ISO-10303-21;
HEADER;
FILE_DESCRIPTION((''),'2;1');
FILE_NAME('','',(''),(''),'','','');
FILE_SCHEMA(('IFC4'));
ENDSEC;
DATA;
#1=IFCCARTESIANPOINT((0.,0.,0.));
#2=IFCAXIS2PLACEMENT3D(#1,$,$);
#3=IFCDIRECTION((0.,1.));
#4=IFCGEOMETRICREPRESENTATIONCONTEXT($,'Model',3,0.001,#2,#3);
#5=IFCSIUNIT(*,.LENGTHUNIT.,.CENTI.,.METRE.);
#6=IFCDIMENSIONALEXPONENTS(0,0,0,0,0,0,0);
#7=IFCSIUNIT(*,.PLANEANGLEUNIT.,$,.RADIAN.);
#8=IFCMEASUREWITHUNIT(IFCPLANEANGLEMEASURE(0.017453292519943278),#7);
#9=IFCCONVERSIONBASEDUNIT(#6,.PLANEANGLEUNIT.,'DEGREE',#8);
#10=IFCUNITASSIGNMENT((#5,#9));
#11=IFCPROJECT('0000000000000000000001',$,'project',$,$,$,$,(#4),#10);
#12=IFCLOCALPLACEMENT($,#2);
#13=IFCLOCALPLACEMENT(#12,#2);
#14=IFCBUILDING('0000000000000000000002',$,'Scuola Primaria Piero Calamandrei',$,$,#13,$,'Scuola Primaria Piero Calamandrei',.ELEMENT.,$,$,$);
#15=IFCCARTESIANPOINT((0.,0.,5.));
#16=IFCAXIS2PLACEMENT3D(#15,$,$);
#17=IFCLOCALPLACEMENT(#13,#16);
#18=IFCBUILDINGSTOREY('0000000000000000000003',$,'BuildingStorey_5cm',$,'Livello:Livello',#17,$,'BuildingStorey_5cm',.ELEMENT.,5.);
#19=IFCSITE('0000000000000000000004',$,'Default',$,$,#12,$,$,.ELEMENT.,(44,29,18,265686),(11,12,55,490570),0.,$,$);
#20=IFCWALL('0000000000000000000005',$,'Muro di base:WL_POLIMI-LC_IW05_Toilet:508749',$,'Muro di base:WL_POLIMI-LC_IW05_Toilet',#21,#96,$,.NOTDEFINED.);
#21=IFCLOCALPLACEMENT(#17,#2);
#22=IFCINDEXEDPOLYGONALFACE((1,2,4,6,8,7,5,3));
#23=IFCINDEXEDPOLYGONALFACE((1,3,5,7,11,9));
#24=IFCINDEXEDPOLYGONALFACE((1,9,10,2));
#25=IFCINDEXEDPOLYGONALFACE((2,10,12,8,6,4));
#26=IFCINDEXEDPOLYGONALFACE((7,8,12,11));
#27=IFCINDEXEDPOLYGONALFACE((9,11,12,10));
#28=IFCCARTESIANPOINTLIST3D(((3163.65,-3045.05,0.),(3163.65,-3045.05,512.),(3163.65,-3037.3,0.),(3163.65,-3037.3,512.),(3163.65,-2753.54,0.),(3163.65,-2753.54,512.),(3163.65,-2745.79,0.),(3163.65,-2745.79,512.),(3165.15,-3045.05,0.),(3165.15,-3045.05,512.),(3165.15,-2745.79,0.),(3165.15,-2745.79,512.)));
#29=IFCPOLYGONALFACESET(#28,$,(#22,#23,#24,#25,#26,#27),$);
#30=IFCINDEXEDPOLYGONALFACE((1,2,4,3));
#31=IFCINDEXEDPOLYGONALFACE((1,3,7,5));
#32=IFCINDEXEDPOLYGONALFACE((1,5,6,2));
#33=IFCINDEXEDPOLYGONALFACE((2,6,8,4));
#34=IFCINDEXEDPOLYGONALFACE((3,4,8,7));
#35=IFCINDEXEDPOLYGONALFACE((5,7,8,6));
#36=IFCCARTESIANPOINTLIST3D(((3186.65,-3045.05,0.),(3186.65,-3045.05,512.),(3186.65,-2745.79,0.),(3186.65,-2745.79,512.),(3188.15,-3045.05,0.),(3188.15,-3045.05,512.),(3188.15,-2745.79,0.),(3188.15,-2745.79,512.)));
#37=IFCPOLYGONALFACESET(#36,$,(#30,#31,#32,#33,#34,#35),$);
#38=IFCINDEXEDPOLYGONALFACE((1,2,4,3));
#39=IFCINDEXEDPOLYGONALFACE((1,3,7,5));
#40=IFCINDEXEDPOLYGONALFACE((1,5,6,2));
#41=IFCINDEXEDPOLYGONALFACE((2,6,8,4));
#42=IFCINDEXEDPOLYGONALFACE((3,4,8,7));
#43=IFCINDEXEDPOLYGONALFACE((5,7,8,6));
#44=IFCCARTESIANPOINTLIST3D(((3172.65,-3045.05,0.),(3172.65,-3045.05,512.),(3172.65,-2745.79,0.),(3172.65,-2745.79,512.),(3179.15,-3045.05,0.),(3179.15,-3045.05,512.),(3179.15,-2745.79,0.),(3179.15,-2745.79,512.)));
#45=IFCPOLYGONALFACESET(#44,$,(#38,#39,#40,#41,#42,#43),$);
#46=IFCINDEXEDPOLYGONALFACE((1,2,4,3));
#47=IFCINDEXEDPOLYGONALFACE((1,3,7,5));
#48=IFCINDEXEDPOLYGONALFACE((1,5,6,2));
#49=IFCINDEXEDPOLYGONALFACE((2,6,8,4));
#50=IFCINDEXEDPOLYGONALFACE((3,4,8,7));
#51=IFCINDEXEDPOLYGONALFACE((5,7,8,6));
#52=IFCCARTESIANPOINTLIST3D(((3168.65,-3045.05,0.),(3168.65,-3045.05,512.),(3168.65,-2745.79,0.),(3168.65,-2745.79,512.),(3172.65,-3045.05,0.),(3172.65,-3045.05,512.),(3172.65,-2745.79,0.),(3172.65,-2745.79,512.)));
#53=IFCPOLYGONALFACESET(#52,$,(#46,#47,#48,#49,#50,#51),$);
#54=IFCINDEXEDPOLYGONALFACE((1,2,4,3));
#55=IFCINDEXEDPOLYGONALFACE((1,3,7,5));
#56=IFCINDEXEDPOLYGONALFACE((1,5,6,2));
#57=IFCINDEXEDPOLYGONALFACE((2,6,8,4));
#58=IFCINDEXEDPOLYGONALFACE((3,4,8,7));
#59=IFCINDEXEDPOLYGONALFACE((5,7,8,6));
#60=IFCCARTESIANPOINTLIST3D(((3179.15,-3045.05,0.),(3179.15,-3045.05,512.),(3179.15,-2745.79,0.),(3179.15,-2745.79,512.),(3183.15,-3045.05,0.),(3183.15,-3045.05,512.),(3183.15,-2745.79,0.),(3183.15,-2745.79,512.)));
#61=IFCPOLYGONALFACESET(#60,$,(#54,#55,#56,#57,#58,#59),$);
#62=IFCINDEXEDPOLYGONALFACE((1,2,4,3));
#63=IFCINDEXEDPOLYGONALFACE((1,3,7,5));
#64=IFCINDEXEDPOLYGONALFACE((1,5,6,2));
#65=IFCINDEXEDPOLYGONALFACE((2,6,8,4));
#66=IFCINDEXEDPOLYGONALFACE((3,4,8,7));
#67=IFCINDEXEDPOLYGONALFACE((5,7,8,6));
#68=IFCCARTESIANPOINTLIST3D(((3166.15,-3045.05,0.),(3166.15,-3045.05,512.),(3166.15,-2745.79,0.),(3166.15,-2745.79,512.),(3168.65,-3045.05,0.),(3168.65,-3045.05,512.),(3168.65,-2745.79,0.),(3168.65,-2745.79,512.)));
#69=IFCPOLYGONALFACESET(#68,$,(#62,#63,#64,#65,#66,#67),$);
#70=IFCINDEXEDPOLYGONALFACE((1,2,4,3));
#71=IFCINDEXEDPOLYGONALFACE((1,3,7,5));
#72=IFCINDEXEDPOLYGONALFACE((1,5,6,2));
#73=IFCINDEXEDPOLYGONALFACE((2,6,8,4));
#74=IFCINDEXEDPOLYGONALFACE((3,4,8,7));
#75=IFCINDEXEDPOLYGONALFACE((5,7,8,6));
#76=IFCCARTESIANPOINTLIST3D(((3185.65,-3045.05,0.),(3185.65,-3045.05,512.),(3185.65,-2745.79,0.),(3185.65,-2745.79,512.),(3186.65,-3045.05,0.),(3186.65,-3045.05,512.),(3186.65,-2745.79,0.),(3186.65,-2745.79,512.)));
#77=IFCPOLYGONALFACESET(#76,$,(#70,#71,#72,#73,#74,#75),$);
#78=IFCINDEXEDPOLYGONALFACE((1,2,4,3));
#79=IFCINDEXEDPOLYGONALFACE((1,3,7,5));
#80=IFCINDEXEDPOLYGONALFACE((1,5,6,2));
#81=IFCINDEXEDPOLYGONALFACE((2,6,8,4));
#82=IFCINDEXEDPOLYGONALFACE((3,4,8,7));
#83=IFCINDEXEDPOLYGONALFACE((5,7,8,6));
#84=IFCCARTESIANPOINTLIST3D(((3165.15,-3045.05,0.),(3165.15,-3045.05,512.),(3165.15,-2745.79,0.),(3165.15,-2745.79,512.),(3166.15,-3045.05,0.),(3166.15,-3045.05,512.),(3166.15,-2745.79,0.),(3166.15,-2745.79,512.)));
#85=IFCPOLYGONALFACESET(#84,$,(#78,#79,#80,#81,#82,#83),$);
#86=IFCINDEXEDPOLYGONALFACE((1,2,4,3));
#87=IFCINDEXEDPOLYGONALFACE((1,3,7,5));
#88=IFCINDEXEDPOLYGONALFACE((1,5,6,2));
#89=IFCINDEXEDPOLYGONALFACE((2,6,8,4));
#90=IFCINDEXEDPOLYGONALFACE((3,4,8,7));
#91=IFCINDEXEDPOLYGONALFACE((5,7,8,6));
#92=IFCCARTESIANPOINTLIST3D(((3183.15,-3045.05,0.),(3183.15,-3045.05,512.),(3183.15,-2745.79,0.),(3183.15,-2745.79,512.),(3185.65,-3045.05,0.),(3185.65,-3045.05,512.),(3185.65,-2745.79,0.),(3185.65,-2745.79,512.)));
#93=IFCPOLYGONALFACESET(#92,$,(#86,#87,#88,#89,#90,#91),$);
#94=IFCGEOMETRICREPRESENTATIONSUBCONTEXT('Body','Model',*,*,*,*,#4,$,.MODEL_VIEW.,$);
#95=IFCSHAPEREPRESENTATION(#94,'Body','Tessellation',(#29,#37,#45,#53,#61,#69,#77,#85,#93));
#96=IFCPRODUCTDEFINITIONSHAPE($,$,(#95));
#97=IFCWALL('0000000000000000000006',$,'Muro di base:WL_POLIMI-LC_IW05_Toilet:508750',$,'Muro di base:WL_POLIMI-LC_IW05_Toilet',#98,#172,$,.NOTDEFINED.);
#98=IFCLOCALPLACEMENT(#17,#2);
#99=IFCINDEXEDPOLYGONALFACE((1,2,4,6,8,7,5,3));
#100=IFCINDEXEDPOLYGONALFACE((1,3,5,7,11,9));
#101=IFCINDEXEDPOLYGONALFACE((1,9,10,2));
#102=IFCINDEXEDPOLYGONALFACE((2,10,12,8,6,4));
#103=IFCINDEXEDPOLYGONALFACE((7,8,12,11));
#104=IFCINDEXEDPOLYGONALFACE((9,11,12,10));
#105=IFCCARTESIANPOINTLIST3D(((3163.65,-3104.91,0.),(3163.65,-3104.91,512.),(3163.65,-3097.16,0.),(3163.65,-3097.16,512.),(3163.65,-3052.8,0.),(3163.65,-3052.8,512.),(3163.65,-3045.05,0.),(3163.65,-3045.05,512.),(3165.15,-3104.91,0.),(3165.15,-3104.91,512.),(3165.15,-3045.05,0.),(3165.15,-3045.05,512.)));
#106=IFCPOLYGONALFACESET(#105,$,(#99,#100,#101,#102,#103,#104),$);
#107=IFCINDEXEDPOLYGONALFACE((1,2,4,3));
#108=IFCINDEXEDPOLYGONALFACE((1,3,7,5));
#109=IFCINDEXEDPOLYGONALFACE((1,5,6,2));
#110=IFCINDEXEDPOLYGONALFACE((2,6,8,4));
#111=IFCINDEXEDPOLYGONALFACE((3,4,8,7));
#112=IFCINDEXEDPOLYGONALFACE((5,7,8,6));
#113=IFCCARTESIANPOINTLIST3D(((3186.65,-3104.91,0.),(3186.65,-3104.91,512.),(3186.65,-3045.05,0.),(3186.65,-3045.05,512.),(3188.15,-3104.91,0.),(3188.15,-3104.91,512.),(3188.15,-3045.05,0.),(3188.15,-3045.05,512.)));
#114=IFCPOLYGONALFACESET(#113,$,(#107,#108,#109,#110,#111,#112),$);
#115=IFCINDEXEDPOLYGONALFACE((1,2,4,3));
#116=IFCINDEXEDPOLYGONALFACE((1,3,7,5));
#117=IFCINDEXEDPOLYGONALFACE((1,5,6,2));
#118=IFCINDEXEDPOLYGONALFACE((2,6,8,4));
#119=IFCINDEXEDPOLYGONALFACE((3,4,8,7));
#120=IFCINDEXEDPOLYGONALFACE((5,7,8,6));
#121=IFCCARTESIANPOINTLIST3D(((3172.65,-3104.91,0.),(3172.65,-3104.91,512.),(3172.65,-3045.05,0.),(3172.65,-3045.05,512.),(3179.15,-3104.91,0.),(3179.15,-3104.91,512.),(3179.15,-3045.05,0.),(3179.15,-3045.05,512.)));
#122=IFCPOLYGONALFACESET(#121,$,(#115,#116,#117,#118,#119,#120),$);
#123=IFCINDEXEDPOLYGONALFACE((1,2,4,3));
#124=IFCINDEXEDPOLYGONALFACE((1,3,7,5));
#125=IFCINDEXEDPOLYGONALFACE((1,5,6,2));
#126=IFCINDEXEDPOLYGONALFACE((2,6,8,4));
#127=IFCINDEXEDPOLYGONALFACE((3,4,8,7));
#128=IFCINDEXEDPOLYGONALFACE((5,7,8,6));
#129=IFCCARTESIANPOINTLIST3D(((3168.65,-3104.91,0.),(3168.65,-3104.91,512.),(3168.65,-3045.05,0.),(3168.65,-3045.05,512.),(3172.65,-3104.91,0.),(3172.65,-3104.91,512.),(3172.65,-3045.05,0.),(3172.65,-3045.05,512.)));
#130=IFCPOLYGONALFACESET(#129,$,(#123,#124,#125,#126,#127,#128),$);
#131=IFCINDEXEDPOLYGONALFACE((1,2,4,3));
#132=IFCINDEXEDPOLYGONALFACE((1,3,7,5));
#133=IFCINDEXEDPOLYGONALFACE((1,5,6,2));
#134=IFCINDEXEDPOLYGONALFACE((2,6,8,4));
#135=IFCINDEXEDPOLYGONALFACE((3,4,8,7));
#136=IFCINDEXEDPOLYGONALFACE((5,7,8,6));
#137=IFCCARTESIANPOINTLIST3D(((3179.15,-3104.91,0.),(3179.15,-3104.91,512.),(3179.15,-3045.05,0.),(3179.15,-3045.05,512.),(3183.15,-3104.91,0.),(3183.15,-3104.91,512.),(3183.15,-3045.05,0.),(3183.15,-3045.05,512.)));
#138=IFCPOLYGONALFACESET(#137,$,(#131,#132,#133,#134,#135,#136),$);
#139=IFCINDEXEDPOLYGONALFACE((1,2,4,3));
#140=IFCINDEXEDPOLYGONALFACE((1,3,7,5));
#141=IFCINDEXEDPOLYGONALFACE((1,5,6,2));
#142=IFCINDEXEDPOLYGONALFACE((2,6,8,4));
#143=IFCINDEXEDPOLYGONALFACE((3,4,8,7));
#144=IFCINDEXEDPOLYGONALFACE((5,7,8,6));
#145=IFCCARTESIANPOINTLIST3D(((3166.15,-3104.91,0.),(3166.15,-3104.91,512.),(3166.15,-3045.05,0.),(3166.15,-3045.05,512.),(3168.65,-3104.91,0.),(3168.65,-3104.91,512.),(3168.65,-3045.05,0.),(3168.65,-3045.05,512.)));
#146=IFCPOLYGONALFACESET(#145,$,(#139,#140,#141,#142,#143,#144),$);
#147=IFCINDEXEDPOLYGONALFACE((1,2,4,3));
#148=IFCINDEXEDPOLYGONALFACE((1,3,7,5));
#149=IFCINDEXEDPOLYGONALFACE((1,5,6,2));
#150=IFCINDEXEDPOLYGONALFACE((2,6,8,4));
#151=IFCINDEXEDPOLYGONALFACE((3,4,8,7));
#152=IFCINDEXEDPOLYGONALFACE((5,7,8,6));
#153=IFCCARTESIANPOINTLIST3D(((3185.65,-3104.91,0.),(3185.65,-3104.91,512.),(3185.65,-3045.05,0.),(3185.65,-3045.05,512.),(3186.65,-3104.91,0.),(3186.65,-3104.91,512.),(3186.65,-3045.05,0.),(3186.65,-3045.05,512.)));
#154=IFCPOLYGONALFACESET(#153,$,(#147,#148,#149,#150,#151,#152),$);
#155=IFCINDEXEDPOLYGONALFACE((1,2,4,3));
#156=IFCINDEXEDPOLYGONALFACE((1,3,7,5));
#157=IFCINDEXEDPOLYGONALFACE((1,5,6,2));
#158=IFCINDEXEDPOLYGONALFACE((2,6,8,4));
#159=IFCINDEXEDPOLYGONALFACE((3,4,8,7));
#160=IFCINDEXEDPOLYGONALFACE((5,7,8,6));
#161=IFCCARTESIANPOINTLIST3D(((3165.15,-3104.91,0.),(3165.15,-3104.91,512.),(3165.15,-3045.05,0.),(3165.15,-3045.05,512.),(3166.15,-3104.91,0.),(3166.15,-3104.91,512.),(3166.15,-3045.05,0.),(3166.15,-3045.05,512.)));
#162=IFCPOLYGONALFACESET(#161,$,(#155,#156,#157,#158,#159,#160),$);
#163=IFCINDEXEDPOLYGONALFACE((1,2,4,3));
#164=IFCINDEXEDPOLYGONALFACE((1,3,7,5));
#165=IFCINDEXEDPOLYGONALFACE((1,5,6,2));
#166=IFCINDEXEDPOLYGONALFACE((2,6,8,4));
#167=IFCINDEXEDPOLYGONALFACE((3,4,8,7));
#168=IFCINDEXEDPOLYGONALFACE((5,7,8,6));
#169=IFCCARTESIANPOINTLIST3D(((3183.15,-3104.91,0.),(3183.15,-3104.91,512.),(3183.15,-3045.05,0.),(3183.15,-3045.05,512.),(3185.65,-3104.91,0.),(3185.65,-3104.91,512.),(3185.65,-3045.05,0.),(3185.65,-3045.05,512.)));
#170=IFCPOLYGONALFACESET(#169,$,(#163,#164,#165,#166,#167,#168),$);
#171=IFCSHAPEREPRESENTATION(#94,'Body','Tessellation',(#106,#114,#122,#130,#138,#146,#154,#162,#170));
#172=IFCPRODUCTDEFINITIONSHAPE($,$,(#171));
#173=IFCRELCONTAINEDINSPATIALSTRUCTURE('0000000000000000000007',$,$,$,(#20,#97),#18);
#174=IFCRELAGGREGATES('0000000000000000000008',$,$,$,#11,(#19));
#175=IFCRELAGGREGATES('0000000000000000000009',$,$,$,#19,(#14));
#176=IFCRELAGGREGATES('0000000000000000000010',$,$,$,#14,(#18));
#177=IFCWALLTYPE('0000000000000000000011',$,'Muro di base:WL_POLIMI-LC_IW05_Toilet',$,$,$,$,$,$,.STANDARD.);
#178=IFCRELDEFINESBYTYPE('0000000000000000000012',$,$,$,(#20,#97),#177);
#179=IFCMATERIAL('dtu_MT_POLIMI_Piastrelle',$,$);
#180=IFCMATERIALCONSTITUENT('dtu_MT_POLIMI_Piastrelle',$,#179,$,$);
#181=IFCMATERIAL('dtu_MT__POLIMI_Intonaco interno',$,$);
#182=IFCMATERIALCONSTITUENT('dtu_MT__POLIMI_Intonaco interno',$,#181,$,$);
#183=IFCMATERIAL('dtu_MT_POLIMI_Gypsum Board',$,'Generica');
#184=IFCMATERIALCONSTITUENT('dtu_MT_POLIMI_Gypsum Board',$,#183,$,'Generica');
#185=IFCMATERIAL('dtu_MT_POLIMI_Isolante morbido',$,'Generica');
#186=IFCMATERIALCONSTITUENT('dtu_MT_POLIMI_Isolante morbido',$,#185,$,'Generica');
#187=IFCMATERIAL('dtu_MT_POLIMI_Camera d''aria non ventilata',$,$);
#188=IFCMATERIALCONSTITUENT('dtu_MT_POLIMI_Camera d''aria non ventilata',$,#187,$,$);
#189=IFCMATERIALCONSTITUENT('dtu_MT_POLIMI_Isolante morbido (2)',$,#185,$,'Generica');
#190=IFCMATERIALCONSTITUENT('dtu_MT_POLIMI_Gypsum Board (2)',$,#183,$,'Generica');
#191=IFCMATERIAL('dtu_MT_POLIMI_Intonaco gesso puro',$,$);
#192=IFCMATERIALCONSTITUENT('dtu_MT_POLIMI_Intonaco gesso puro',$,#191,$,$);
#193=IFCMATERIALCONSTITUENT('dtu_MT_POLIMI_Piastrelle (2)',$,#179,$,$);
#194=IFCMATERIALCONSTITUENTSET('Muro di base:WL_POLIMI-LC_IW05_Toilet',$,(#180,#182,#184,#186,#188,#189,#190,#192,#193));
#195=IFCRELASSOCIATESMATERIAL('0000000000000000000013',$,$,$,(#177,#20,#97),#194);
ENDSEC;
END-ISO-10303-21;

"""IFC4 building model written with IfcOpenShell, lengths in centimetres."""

from ifc_helpers import new_model, entity, si_unit, converted_unit, direction, frame, origin, place, context, subcontext, project, spatial, indexed_curve, outline, extrude, material, constituent, constituent_set, type_object, element, save


model = new_model("IFC4")

# Units and contexts
model_context = context("Model", 3, precision=0.001, world=origin(), true_north=direction((0.0, 1.0)))
body_context = subcontext(model_context, "Body", "Model", "MODEL_VIEW")
ifc_project = project(units=[si_unit("LENGTHUNIT", "METRE", prefix="CENTI"), converted_unit("PLANEANGLEUNIT", "DEGREE", entity("IfcPlaneAngleMeasure", 0.017453292519943278), si_unit("PLANEANGLEUNIT", "RADIAN"), dimensions=[0, 0, 0, 0, 0, 0, 0])], contexts=[model_context])

# Site, building, storey
site_placement = place(None, origin())
site = spatial("IfcSite", under=ifc_project, at=site_placement, Name="Default", CompositionType="ELEMENT", RefLatitude=(44, 29, 18, 265686), RefLongitude=(11, 12, 55, 490570), RefElevation=0.0)
building_placement = place(site_placement, origin())
building = spatial("IfcBuilding", under=site, at=building_placement, Name="Scuola Primaria Piero Calamandrei", LongName="Scuola Primaria Piero Calamandrei", CompositionType="ELEMENT")
storey_placement = place(building_placement, frame((0.0, 0.0, 5.0)))
storey = spatial("IfcBuildingStorey", under=building, at=storey_placement, Name="BuildingStorey_5cm", ObjectType="Livello:Livello", LongName="BuildingStorey_5cm", CompositionType="ELEMENT", Elevation=5.0)

# Shared definitions
ifc_material_1 = material(Name="dtu_MT_POLIMI_Intonaco gesso puro")

# Shared definitions
ifc_material_2 = material(Name="dtu_MT_POLIMI_Isolante morbido", Category="Generica")
ifc_material_3 = material(Name="dtu_MT_POLIMI_Gypsum Board", Category="Generica")
ifc_material_4 = material(Name="dtu_MT__POLIMI_Intonaco interno")
ifc_material_5 = material(Name="dtu_MT_POLIMI_Camera d'aria non ventilata")

# Walls
ifc_material_6 = material(Name="dtu_MT_POLIMI_Piastrelle")
ifc_constituent_1 = constituent(ifc_material_6, Name="dtu_MT_POLIMI_Piastrelle")
ifc_constituent_2 = constituent(ifc_material_4, Name="dtu_MT__POLIMI_Intonaco interno")
ifc_constituent_3 = constituent(ifc_material_3, Name="dtu_MT_POLIMI_Gypsum Board", Category="Generica")
ifc_constituent_4 = constituent(ifc_material_2, Name="dtu_MT_POLIMI_Isolante morbido", Category="Generica")
ifc_constituent_5 = constituent(ifc_material_5, Name="dtu_MT_POLIMI_Camera d'aria non ventilata")
ifc_constituent_6 = constituent(ifc_material_2, Name="dtu_MT_POLIMI_Isolante morbido (2)", Category="Generica")
ifc_constituent_7 = constituent(ifc_material_3, Name="dtu_MT_POLIMI_Gypsum Board (2)", Category="Generica")
ifc_constituent_8 = constituent(ifc_material_1, Name="dtu_MT_POLIMI_Intonaco gesso puro")
ifc_constituent_9 = constituent(ifc_material_6, Name="dtu_MT_POLIMI_Piastrelle (2)")
ifc_constituent_set_1 = constituent_set(constituents=[ifc_constituent_1, ifc_constituent_2, ifc_constituent_3, ifc_constituent_4, ifc_constituent_5, ifc_constituent_6, ifc_constituent_7, ifc_constituent_8, ifc_constituent_9], Name="Muro di base:WL_POLIMI-LC_IW05_Toilet")
wall_type_1 = type_object("IfcWallType", Name="Muro di base:WL_POLIMI-LC_IW05_Toilet", PredefinedType="STANDARD", material=ifc_constituent_set_1)
wall_1_placement = place(storey_placement, frame((3175.9, -3045.05, 0.0), z_axis=(0.0, 0.0, 1.0), x_axis=(0.0, 1.0, 0.0)))
element("IfcWall", 1, at=wall_1_placement, inside=storey, type_object=wall_type_1, material=ifc_constituent_set_1, Name="Muro di base:WL_POLIMI-LC_IW05_Toilet:508749", ObjectType="Muro di base:WL_POLIMI-LC_IW05_Toilet", PredefinedType="NOTDEFINED", context=body_context, shape_type="SweptSolid", body=[
    extrude(outline(indexed_curve([(-141.88, -0.5), (141.88, -0.5), (149.63, -0.5), (149.63, 1.0), (-149.63, 1.0), (-149.63, -0.5), (-141.88, -0.5)], self_intersect=False)), frame((149.63, 11.75, 0.0), z_axis=(0.0, 0.0, 1.0), x_axis=(-1.0, 0.0, 0.0)), (0.0, 0.0, 1.0), 512.0),
    extrude(outline(indexed_curve([(-0.75, -149.63), (0.75, -149.63), (0.75, 149.63), (-0.75, 149.63), (-0.75, -149.63)], self_intersect=False)), frame((149.63, -11.5, 0.0), z_axis=(0.0, 0.0, 1.0), x_axis=(0.0, 1.0, 0.0)), (0.0, 0.0, 1.0), 512.0),
    extrude(outline(indexed_curve([(-149.63, -3.25), (149.63, -3.25), (149.63, 3.25), (-149.63, 3.25), (-149.63, -3.25)], self_intersect=False)), frame((149.63, 0.0, 0.0)), (0.0, 0.0, 1.0), 512.0),
    extrude(outline(indexed_curve([(-149.63, -2.0), (149.63, -2.0), (149.63, 2.0), (-149.63, 2.0), (-149.63, -2.0)], self_intersect=False)), frame((149.63, 5.25, 0.0)), (0.0, 0.0, 1.0), 512.0),
    extrude(outline(indexed_curve([(-149.63, -2.0), (149.63, -2.0), (149.63, 2.0), (-149.63, 2.0), (-149.63, -2.0)], self_intersect=False)), frame((149.63, -5.25, 0.0)), (0.0, 0.0, 1.0), 512.0),
    extrude(outline(indexed_curve([(-149.63, -1.25), (149.63, -1.25), (149.63, 1.25), (-149.63, 1.25), (-149.63, -1.25)], self_intersect=False)), frame((149.63, 8.5, 0.0)), (0.0, 0.0, 1.0), 512.0),
    extrude(outline(indexed_curve([(-149.63, -0.5), (149.63, -0.5), (149.63, 0.5), (-149.63, 0.5), (-149.63, -0.5)], self_intersect=False)), frame((149.63, -10.25, 0.0)), (0.0, 0.0, 1.0), 512.0),
    extrude(outline(indexed_curve([(-149.63, -0.5), (149.63, -0.5), (149.63, 0.5), (-149.63, 0.5), (-149.63, -0.5)], self_intersect=False)), frame((149.63, 10.25, 0.0)), (0.0, 0.0, 1.0), 512.0),
    extrude(outline(indexed_curve([(-149.63, -1.25), (149.63, -1.25), (149.63, 1.25), (-149.63, 1.25), (-149.63, -1.25)], self_intersect=False)), frame((149.63, -8.5, 0.0)), (0.0, 0.0, 1.0), 512.0),
])
wall_2_placement = place(storey_placement, frame((3175.9, -3104.91, 0.0), z_axis=(0.0, 0.0, 1.0), x_axis=(0.0, 1.0, 0.0)))
element("IfcWall", 2, at=wall_2_placement, inside=storey, type_object=wall_type_1, material=ifc_constituent_set_1, Name="Muro di base:WL_POLIMI-LC_IW05_Toilet:508750", ObjectType="Muro di base:WL_POLIMI-LC_IW05_Toilet", PredefinedType="NOTDEFINED", context=body_context, shape_type="SweptSolid", body=[
    extrude(outline(indexed_curve([(-22.18, -0.5), (22.18, -0.5), (29.93, -0.5), (29.93, 1.0), (-29.93, 1.0), (-29.93, -0.5), (-22.18, -0.5)], self_intersect=False)), frame((29.93, 11.75, 0.0), z_axis=(0.0, 0.0, 1.0), x_axis=(-1.0, 0.0, 0.0)), (0.0, 0.0, 1.0), 512.0),
    extrude(outline(indexed_curve([(-0.75, -29.93), (0.75, -29.93), (0.75, 29.93), (-0.75, 29.93), (-0.75, -29.93)], self_intersect=False)), frame((29.93, -11.5, 0.0), z_axis=(0.0, 0.0, 1.0), x_axis=(0.0, 1.0, 0.0)), (0.0, 0.0, 1.0), 512.0),
    extrude(outline(indexed_curve([(-29.93, -3.25), (29.93, -3.25), (29.93, 3.25), (-29.93, 3.25), (-29.93, -3.25)], self_intersect=False)), frame((29.93, 0.0, 0.0)), (0.0, 0.0, 1.0), 512.0),
    extrude(outline(indexed_curve([(-29.93, -2.0), (29.93, -2.0), (29.93, 2.0), (-29.93, 2.0), (-29.93, -2.0)], self_intersect=False)), frame((29.93, 5.25, 0.0)), (0.0, 0.0, 1.0), 512.0),
    extrude(outline(indexed_curve([(-29.93, -2.0), (29.93, -2.0), (29.93, 2.0), (-29.93, 2.0), (-29.93, -2.0)], self_intersect=False)), frame((29.93, -5.25, 0.0)), (0.0, 0.0, 1.0), 512.0),
    extrude(outline(indexed_curve([(-29.93, -1.25), (29.93, -1.25), (29.93, 1.25), (-29.93, 1.25), (-29.93, -1.25)], self_intersect=False)), frame((29.93, 8.5, 0.0)), (0.0, 0.0, 1.0), 512.0),
    extrude(outline(indexed_curve([(-29.93, -0.5), (29.93, -0.5), (29.93, 0.5), (-29.93, 0.5), (-29.93, -0.5)], self_intersect=False)), frame((29.93, -10.25, 0.0)), (0.0, 0.0, 1.0), 512.0),
    extrude(outline(indexed_curve([(-29.93, -0.5), (29.93, -0.5), (29.93, 0.5), (-29.93, 0.5), (-29.93, -0.5)], self_intersect=False)), frame((29.93, 10.25, 0.0)), (0.0, 0.0, 1.0), 512.0),
    extrude(outline(indexed_curve([(-29.93, -1.25), (29.93, -1.25), (29.93, 1.25), (-29.93, 1.25), (-29.93, -1.25)], self_intersect=False)), frame((29.93, -8.5, 0.0)), (0.0, 0.0, 1.0), 512.0),
])

save(model, "model.ifc")
